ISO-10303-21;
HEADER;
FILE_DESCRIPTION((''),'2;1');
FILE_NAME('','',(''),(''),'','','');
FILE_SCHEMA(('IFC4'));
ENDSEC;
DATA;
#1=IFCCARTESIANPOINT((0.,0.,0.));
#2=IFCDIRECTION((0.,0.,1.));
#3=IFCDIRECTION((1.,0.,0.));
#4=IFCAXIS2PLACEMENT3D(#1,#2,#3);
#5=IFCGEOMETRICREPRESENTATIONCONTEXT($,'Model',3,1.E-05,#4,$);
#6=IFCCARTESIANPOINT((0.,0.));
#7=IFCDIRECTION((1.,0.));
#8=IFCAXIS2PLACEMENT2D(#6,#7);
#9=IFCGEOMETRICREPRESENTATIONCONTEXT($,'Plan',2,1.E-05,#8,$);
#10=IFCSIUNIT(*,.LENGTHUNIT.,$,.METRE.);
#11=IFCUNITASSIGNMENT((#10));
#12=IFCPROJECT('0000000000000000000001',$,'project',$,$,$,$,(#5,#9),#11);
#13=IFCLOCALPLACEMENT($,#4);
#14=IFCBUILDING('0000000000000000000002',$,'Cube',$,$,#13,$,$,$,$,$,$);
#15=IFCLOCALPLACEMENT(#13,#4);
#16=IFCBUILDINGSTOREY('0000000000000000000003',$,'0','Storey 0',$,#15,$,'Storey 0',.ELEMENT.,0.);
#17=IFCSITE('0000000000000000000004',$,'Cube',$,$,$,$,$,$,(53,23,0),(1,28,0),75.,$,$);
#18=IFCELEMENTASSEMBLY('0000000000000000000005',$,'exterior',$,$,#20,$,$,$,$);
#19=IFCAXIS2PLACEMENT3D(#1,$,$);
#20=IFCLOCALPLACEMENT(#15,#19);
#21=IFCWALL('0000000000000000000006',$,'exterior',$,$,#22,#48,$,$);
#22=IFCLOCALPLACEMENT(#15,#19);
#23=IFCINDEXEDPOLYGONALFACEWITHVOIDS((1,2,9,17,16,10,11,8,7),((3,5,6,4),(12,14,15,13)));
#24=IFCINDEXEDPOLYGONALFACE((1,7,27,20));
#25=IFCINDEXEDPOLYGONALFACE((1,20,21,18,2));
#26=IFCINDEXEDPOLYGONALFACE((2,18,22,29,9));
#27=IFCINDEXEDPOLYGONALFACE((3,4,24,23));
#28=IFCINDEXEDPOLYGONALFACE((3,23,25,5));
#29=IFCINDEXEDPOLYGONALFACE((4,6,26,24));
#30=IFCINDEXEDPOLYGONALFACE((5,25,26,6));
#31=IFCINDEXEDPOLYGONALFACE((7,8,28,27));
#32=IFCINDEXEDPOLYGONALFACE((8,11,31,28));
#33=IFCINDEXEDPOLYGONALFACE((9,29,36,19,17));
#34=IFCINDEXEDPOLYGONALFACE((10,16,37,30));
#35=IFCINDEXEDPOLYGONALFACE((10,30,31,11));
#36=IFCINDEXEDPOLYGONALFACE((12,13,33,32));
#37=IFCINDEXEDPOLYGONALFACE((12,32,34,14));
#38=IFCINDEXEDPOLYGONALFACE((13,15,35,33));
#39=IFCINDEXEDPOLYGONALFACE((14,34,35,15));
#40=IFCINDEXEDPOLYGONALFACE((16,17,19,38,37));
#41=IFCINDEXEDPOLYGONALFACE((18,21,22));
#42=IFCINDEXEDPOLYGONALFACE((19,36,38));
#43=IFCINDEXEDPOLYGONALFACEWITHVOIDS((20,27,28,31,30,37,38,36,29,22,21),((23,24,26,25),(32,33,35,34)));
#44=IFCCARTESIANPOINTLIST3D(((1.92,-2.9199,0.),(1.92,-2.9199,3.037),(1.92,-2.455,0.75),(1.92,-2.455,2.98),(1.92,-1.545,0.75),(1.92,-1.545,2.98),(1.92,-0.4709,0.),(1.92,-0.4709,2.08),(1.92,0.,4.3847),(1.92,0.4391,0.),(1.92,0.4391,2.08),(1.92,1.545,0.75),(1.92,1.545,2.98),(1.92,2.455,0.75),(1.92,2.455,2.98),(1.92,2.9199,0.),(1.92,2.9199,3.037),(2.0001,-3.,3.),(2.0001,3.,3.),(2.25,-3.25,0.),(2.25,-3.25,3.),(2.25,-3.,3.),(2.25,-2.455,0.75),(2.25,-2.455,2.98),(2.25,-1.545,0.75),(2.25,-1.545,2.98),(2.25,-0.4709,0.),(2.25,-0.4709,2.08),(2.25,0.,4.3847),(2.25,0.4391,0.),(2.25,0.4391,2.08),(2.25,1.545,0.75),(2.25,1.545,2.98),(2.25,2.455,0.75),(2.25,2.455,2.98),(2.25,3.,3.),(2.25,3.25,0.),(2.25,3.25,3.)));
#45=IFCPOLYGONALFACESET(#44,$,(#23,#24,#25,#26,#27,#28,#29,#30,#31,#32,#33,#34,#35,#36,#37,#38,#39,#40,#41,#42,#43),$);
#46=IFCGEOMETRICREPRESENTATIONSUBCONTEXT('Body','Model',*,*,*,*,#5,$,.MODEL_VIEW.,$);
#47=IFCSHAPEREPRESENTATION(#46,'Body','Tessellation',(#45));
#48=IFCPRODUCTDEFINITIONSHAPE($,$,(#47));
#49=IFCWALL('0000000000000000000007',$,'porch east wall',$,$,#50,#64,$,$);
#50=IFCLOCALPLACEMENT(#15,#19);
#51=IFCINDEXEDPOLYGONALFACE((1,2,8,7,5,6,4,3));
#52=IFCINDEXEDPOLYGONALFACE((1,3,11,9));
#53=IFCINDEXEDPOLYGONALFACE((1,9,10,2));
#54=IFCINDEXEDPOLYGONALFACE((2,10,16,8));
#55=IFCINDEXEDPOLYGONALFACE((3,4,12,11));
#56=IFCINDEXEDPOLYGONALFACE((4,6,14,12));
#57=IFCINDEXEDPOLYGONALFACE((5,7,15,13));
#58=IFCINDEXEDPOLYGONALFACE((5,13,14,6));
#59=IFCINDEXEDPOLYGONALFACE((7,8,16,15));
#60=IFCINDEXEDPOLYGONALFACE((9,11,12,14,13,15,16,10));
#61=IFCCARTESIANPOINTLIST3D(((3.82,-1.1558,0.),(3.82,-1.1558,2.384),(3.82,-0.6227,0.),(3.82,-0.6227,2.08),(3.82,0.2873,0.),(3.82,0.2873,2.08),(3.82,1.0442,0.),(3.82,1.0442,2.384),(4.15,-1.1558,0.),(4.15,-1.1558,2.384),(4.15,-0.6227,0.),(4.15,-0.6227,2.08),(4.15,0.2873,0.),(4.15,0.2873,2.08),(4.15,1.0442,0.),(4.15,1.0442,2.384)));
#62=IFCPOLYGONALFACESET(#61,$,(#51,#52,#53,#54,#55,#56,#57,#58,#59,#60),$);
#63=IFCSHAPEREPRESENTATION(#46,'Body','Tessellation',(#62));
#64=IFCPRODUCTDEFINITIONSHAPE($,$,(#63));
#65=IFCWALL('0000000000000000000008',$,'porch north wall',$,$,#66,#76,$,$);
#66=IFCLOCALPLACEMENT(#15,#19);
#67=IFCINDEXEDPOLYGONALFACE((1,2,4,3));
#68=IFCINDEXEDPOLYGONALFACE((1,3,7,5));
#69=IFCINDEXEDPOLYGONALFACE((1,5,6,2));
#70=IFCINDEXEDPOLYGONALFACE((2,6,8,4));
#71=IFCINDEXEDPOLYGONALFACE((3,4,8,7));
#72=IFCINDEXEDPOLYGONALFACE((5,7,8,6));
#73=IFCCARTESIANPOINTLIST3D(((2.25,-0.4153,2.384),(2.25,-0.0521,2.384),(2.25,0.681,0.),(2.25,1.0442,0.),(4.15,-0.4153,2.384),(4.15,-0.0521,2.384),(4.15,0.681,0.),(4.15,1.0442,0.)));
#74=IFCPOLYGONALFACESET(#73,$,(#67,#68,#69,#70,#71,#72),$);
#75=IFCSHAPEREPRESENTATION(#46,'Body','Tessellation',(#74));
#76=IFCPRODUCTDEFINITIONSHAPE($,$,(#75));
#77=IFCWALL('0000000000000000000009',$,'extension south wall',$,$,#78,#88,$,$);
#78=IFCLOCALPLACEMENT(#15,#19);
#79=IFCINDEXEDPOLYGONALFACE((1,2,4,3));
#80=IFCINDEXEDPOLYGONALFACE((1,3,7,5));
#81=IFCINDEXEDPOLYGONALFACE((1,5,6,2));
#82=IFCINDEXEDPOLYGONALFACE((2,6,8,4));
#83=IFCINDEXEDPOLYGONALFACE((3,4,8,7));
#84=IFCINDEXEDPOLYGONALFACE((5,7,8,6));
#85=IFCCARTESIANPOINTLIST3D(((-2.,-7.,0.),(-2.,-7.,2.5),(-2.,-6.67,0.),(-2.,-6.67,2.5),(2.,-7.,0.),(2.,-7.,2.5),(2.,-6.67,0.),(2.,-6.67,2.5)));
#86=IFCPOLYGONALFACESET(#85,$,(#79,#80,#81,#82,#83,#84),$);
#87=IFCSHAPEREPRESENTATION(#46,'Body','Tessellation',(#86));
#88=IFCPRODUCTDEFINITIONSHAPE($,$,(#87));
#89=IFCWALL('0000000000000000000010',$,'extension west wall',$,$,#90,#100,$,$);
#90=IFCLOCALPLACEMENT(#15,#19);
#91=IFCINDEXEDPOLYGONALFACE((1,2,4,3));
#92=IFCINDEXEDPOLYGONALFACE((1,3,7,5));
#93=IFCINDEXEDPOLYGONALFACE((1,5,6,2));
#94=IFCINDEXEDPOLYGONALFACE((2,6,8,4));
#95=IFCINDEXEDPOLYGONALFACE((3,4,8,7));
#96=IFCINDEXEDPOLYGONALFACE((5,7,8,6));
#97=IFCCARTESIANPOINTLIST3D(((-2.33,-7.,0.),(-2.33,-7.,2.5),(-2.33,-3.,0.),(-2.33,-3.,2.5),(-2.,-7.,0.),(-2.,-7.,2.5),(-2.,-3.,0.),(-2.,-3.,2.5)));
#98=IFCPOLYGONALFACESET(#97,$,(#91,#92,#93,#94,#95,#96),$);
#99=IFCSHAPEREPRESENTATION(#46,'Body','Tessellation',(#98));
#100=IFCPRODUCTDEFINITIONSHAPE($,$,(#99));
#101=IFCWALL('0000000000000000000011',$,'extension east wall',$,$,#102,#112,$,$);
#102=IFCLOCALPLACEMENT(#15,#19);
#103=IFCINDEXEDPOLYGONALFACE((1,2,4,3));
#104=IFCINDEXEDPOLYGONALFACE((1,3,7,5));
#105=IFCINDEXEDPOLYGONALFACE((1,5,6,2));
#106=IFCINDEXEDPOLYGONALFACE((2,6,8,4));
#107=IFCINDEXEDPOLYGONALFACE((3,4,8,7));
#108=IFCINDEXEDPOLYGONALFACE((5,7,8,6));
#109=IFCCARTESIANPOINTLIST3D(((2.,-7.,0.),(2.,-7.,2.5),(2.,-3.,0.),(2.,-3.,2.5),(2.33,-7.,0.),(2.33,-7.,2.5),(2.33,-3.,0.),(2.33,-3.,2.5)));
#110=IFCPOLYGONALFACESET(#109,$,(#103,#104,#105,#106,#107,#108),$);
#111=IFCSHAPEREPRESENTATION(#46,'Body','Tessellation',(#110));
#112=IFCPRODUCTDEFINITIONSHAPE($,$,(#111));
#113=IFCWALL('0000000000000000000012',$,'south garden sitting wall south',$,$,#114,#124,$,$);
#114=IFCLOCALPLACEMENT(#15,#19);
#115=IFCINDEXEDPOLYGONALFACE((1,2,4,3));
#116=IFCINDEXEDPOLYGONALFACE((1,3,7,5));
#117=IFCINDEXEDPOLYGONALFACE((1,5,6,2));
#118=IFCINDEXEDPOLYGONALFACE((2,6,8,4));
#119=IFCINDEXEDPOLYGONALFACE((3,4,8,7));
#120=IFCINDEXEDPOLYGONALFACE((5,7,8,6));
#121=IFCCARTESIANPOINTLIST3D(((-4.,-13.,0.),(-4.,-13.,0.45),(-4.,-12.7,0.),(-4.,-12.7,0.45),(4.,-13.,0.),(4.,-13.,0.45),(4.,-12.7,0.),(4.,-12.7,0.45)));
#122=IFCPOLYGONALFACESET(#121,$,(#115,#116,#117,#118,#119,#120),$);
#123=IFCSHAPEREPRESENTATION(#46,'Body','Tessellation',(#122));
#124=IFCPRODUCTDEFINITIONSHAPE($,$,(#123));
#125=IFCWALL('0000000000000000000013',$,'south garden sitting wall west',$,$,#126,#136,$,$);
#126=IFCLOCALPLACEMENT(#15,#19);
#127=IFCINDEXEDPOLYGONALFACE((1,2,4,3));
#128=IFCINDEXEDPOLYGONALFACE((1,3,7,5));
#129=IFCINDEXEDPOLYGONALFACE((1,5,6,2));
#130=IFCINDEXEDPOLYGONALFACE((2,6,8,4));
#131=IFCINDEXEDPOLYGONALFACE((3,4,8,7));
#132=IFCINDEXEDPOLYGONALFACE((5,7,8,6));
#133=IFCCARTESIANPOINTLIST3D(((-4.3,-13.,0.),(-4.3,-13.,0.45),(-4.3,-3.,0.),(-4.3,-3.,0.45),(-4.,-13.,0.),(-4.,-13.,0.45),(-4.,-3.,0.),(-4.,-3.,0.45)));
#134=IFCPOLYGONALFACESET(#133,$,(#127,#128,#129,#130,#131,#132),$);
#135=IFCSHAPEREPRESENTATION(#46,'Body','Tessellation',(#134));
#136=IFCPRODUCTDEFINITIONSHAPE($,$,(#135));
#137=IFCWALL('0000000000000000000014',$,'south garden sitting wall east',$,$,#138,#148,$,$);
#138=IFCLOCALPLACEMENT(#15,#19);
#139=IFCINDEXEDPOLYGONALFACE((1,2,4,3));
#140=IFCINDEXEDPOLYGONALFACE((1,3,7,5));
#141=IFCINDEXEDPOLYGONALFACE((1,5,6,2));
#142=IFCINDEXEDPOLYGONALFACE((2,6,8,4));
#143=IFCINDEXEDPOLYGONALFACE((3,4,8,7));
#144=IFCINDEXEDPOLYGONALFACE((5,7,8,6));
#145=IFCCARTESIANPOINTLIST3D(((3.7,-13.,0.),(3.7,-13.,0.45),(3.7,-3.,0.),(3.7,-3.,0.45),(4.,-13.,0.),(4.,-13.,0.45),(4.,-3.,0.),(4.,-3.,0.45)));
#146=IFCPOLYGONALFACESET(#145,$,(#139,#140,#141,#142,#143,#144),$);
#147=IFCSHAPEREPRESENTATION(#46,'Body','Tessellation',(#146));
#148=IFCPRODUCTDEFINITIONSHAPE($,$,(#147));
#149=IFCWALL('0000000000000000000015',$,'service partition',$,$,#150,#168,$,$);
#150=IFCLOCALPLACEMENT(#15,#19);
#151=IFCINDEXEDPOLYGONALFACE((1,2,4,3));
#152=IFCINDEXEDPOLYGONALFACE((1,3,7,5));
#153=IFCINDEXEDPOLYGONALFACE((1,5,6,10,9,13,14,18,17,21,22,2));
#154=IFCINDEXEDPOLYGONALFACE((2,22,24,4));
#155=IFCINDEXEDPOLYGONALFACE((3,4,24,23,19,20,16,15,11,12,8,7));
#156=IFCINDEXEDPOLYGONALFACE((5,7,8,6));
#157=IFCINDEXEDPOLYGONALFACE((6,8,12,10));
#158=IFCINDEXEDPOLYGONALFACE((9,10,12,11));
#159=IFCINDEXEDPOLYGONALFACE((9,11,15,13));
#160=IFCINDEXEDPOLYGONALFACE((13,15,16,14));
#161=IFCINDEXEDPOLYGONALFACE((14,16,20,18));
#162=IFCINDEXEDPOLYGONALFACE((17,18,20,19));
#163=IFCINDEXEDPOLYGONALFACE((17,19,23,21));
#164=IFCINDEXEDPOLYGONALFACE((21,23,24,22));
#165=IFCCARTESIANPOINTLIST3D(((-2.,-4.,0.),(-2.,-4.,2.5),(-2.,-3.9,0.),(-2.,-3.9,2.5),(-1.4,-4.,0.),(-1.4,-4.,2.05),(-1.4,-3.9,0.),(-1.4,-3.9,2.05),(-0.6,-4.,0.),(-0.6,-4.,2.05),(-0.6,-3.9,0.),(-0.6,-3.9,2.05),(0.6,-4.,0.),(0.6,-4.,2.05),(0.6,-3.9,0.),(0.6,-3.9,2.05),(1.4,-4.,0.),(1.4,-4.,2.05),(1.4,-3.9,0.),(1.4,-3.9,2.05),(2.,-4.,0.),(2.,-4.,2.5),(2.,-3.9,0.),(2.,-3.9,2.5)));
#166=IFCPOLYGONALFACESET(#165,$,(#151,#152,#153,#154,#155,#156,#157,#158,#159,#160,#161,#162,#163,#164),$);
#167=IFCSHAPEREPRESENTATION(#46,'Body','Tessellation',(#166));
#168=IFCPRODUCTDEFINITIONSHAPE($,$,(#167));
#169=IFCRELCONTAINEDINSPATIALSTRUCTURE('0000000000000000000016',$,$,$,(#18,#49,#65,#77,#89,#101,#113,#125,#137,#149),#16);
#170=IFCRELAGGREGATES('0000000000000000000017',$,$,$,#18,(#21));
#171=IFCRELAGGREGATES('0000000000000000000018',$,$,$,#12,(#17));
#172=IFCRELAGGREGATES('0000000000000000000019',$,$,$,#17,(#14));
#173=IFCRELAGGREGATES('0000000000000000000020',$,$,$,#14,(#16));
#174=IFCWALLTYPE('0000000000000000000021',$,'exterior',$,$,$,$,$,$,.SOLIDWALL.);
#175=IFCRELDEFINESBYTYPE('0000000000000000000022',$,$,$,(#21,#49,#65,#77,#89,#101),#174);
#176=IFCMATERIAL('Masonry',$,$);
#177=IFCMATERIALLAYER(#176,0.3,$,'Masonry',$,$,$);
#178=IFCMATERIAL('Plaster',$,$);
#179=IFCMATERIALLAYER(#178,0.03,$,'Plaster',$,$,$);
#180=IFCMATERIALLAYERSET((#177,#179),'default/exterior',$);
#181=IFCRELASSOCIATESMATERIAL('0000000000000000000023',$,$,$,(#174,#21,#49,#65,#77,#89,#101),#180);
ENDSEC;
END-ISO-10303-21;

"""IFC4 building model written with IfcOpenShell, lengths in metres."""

from ifc_helpers import new_model, si_unit, frame, origin, origin_with_axes, origin_2d_with_axis, place, context, subcontext, project, spatial, polyline, line, indexed_curve, outline, extrude, clip, bounded_halfspace, source, transform, mapped, material, layer, layer_set, layer_usage, type_object, element, aggregate, save


model = new_model("IFC4")

# Units and contexts
model_context = context("Model", 3, precision=1e-05, world=origin_with_axes())
plan_context = context("Plan", 2, precision=1e-05, world=origin_2d_with_axis())
body_context = subcontext(model_context, "Body", "Model", "MODEL_VIEW")
ifc_project = project(units=[si_unit("LENGTHUNIT", "METRE")], contexts=[model_context, plan_context])

# Site, building, storey
site = spatial("IfcSite", under=ifc_project, Name="Cube", RefLatitude=(53, 23, 0), RefLongitude=(1, 28, 0), RefElevation=75.0)
building_placement = place(None, origin_with_axes())
building = spatial("IfcBuilding", under=site, at=building_placement, Name="Cube")
storey_placement = place(building_placement, origin_with_axes())
storey = spatial("IfcBuildingStorey", under=building, at=storey_placement, Name="0", Description="Storey 0", LongName="Storey 0", CompositionType="ELEMENT", Elevation=0.0)

# Element assembly, wall, openings
ifc_material_1 = material(Name="Masonry")
ifc_layer_1 = layer(ifc_material_1, 0.3, Name="Masonry")
ifc_material_2 = material(Name="Plaster")
ifc_layer_2 = layer(ifc_material_2, 0.03, Name="Plaster")
ifc_layer_set_1 = layer_set([ifc_layer_1, ifc_layer_2], Name="default/exterior")
wall_type = type_object("IfcWallType", Name="exterior", PredefinedType="SOLIDWALL", material=ifc_layer_set_1)
assembly_1_placement = place(storey_placement, frame((2.0, -3.0, 0.0), z_axis=(0.0, 0.0, 1.0), x_axis=(0.0, 1.0, 0.0)))
assembly_1 = element("IfcElementAssembly", 1, at=assembly_1_placement, inside=storey, Name="exterior")
ifc_layer_usage_1 = layer_usage(ifc_layer_set_1, "AXIS2", "POSITIVE", -0.25)
wall_1_placement = place(assembly_1_placement, origin_with_axes())
wall_1 = element("IfcWall", 2, at=wall_1_placement, type_object=wall_type, material=ifc_layer_usage_1, Name="exterior", context=body_context, shape_type="Clipping", body=[
    clip(clip(clip(clip(extrude(outline(polyline([(0.0801, 0.08), (-0.25, -0.25), (6.25, -0.25), (5.9199, 0.08), (0.0801, 0.08)])), origin(), (0.0, 0.0, 1.0), 4.385), bounded_halfspace(frame((6.0, 0.0, 3.0), z_axis=(0.419069, 0.0, 0.907954), x_axis=(0.0, -1.0, 0.0)), False, origin(), polyline([(6.0, -1.0), (3.0, -1.0), (3.0, 1.0), (6.0, 1.0), (6.0, -1.0)]))), bounded_halfspace(frame((6.0, 0.0, 3.0), z_axis=(0.0, 0.0, 1.0), x_axis=(0.0, 1.0, 0.0)), False, origin(), polyline([(6.0, 1.0), (7.0, 1.0), (7.0, -1.0), (6.0, -1.0), (6.0, 1.0)]))), bounded_halfspace(frame((3.0, 0.0, 4.3847), z_axis=(-0.419069, 0.0, 0.907954), x_axis=(0.0, -1.0, 0.0)), False, origin(), polyline([(3.0, -1.0), (0.0, -1.0), (0.0, 1.0), (3.0, 1.0), (3.0, -1.0)]))), bounded_halfspace(frame((0.0, 0.0, 3.0), z_axis=(0.0, 0.0, 1.0), x_axis=(0.0, -1.0, 0.0)), False, origin(), polyline([(0.0, -1.0), (-1.0, -1.0), (-1.0, 1.0), (0.0, 1.0), (0.0, -1.0)]))),
])
opening_1_placement = place(wall_1_placement, frame((0.545, -0.25, 0.75), z_axis=(0.0, 0.0, 1.0), x_axis=(1.0, 0.0, 0.0)))
element("IfcOpeningElement", 3, at=opening_1_placement, cuts=wall_1, PredefinedType="OPENING", context=body_context, shape_type="SweptSolid", body=[
    extrude(outline(polyline([(0.0, -0.02), (0.91, -0.02), (0.91, 0.35), (0.0, 0.35), (0.0, -0.02)])), origin(), (0.0, 0.0, 1.0), 2.23),
])
opening_2_placement = place(wall_1_placement, frame((4.545, -0.25, 0.75), z_axis=(0.0, 0.0, 1.0), x_axis=(1.0, 0.0, 0.0)))
element("IfcOpeningElement", 4, at=opening_2_placement, cuts=wall_1, PredefinedType="OPENING", context=body_context, shape_type="SweptSolid", body=[
    extrude(outline(polyline([(0.0, -0.02), (0.91, -0.02), (0.91, 0.35), (0.0, 0.35), (0.0, -0.02)])), origin(), (0.0, 0.0, 1.0), 2.23),
])
shared_shape_1 = source(origin_with_axes(), body_context, "Body", "SweptSolid", [
    extrude(outline(indexed_curve([(0.0, 0.0), (0.91, 0.0), (0.91, 2.08), (0.0, 2.08)], segments=[line(1, 2, 3, 4, 1)])), frame((0.0, -0.6, 0.0), z_axis=(0.0, -1.0, 0.0), x_axis=(1.0, 0.0, 0.0)), (0.0, 0.0, -1.0), 1.2),
])
opening_3_placement = place(wall_1_placement, frame((2.5291, -0.25, 0.0), z_axis=(0.0, 0.0, 1.0), x_axis=(1.0, 0.0, 0.0)))
element("IfcOpeningElement", 5, at=opening_3_placement, cuts=wall_1, PredefinedType="OPENING", context=body_context, shape_type="MappedRepresentation", body=[
    mapped(shared_shape_1, transform((0.0, 0.0, 0.0), x_axis=(1.0, 0.0, 0.0), y_axis=(0.0, 1.0, 0.0), z_axis=(0.0, 0.0, 1.0), scale=1.0)),
])
aggregate(assembly_1, [wall_1])

# Wall, opening
ifc_layer_usage_2 = layer_usage(ifc_layer_set_1, "AXIS2", "POSITIVE", 0.0)
wall_2_placement = place(storey_placement, frame((4.15, -1.1558, 0.0), z_axis=(0.0, 0.0, 1.0), x_axis=(0.0, 1.0, 0.0)))
wall_2 = element("IfcWall", 6, at=wall_2_placement, inside=storey, type_object=wall_type, material=ifc_layer_usage_2, Name="porch east wall", context=body_context, shape_type="SweptSolid", body=[
    extrude(outline(indexed_curve([(0.0, 0.0), (0.0, 0.33), (2.2, 0.33), (2.2, 0.0), (0.0, 0.0)], self_intersect=False)), origin_with_axes(), (0.0, 0.0, 1.0), 2.384),
])
shared_shape_2 = source(origin_with_axes(), body_context, "Body", "SweptSolid", [
    extrude(outline(indexed_curve([(0.0, 0.0), (0.91, 0.0), (0.91, 2.08), (0.0, 2.08)], segments=[line(1, 2, 3, 4, 1)])), frame((0.0, -0.6, 0.0), z_axis=(0.0, -1.0, 0.0), x_axis=(1.0, 0.0, 0.0)), (0.0, 0.0, -1.0), 1.2),
])
opening_4_placement = place(wall_2_placement, frame((0.5331, 0.0, 0.0), z_axis=(0.0, 0.0, 1.0), x_axis=(1.0, 0.0, 0.0)))
element("IfcOpeningElement", 7, at=opening_4_placement, cuts=wall_2, PredefinedType="OPENING", context=body_context, shape_type="MappedRepresentation", body=[
    mapped(shared_shape_2, transform((0.0, 0.0, 0.0), x_axis=(1.0, 0.0, 0.0), y_axis=(0.0, 1.0, 0.0), z_axis=(0.0, 0.0, 1.0), scale=1.0)),
])

# Walls
ifc_layer_usage_3 = layer_usage(ifc_layer_set_1, "AXIS2", "POSITIVE", 0.0)
wall_3_placement = place(storey_placement, frame((4.15, 1.0442, 0.0), z_axis=(0.0, 0.0, 1.0), x_axis=(-1.0, 0.0, 0.0)))
element("IfcWall", 8, at=wall_3_placement, inside=storey, type_object=wall_type, material=ifc_layer_usage_3, Name="porch north wall", context=body_context, shape_type="SweptSolid", body=[
    extrude(outline(indexed_curve([(0.0, 0.0), (0.0, 0.3632), (1.9, 0.3632), (1.9, 0.0), (0.0, 0.0)], self_intersect=False)), origin_with_axes(), (0.0, 0.41778, 0.908548), 2.624),
])
ifc_layer_usage_4 = layer_usage(ifc_layer_set_1, "AXIS2", "POSITIVE", 0.0)
for number, where, z_axis, x_axis, name in (
    (9, (-2.0, -7.0, 0.0), (0.0, 0.0, 1.0), (1.0, 0.0, 0.0), "extension south wall"),
    (10, (-2.0, -7.0, 0.0), (0.0, 0.0, 1.0), (0.0, 1.0, 0.0), "extension west wall"),
    (11, (2.0, -3.0, 0.0), (0.0, 0.0, 1.0), (0.0, -1.0, 0.0), "extension east wall"),
):
    element("IfcWall", number, at=place(storey_placement, frame(where, z_axis=z_axis, x_axis=x_axis)), inside=storey, type_object=wall_type, material=ifc_layer_usage_4, Name=name, context=body_context, shape_type="SweptSolid", body=[
        extrude(outline(indexed_curve([(0.0, 0.0), (0.0, 0.33), (4.0, 0.33), (4.0, 0.0), (0.0, 0.0)], self_intersect=False)), origin_with_axes(), (0.0, 0.0, 1.0), 2.5),
    ])
wall_4_placement = place(storey_placement, frame((-4.0, -13.0, 0.0), z_axis=(0.0, 0.0, 1.0), x_axis=(1.0, 0.0, 0.0)))
element("IfcWall", 12, at=wall_4_placement, inside=storey, Name="south garden sitting wall south", context=body_context, shape_type="SweptSolid", body=[
    extrude(outline(indexed_curve([(0.0, 0.0), (0.0, 0.3), (8.0, 0.3), (8.0, 0.0), (0.0, 0.0)], self_intersect=False)), origin_with_axes(), (0.0, 0.0, 1.0), 0.45),
])
for number, where, z_axis, x_axis, name in (
    (13, (-4.0, -13.0, 0.0), (0.0, 0.0, 1.0), (0.0, 1.0, 0.0), "south garden sitting wall west"),
    (14, (4.0, -13.0, 0.0), (0.0, 0.0, 1.0), (0.0, 1.0, 0.0), "south garden sitting wall east"),
):
    element("IfcWall", number, at=place(storey_placement, frame(where, z_axis=z_axis, x_axis=x_axis)), inside=storey, Name=name, context=body_context, shape_type="SweptSolid", body=[
        extrude(outline(indexed_curve([(0.0, 0.0), (0.0, 0.3), (10.0, 0.3), (10.0, 0.0), (0.0, 0.0)], self_intersect=False)), origin_with_axes(), (0.0, 0.0, 1.0), 0.45),
    ])

# Wall, openings
wall_5_placement = place(storey_placement, frame((-2.0, -4.0, 0.0), z_axis=(0.0, 0.0, 1.0), x_axis=(1.0, 0.0, 0.0)))
wall_5 = element("IfcWall", 15, at=wall_5_placement, inside=storey, Name="service partition", context=body_context, shape_type="SweptSolid", body=[
    extrude(outline(indexed_curve([(0.0, 0.0), (0.0, 0.1), (4.0, 0.1), (4.0, 0.0), (0.0, 0.0)], self_intersect=False)), origin_with_axes(), (0.0, 0.0, 1.0), 2.5),
])
opening_5_placement = place(wall_5_placement, frame((0.6, -0.05, 0.0), z_axis=(0.0, 0.0, 1.0), x_axis=(1.0, 0.0, 0.0)))
element("IfcOpeningElement", 16, at=opening_5_placement, cuts=wall_5, context=body_context, shape_type="SweptSolid", body=[
    extrude(outline(indexed_curve([(0.0, 0.0), (0.0, 0.3), (0.8, 0.3), (0.8, 0.0), (0.0, 0.0)], self_intersect=False)), origin_with_axes(), (0.0, 0.0, 1.0), 2.05),
])
opening_6_placement = place(wall_5_placement, frame((2.6, -0.05, 0.0), z_axis=(0.0, 0.0, 1.0), x_axis=(1.0, 0.0, 0.0)))
element("IfcOpeningElement", 17, at=opening_6_placement, cuts=wall_5, context=body_context, shape_type="SweptSolid", body=[
    extrude(outline(indexed_curve([(0.0, 0.0), (0.0, 0.3), (0.8, 0.3), (0.8, 0.0), (0.0, 0.0)], self_intersect=False)), origin_with_axes(), (0.0, 0.0, 1.0), 2.05),
])

save(model, "model.ifc")
